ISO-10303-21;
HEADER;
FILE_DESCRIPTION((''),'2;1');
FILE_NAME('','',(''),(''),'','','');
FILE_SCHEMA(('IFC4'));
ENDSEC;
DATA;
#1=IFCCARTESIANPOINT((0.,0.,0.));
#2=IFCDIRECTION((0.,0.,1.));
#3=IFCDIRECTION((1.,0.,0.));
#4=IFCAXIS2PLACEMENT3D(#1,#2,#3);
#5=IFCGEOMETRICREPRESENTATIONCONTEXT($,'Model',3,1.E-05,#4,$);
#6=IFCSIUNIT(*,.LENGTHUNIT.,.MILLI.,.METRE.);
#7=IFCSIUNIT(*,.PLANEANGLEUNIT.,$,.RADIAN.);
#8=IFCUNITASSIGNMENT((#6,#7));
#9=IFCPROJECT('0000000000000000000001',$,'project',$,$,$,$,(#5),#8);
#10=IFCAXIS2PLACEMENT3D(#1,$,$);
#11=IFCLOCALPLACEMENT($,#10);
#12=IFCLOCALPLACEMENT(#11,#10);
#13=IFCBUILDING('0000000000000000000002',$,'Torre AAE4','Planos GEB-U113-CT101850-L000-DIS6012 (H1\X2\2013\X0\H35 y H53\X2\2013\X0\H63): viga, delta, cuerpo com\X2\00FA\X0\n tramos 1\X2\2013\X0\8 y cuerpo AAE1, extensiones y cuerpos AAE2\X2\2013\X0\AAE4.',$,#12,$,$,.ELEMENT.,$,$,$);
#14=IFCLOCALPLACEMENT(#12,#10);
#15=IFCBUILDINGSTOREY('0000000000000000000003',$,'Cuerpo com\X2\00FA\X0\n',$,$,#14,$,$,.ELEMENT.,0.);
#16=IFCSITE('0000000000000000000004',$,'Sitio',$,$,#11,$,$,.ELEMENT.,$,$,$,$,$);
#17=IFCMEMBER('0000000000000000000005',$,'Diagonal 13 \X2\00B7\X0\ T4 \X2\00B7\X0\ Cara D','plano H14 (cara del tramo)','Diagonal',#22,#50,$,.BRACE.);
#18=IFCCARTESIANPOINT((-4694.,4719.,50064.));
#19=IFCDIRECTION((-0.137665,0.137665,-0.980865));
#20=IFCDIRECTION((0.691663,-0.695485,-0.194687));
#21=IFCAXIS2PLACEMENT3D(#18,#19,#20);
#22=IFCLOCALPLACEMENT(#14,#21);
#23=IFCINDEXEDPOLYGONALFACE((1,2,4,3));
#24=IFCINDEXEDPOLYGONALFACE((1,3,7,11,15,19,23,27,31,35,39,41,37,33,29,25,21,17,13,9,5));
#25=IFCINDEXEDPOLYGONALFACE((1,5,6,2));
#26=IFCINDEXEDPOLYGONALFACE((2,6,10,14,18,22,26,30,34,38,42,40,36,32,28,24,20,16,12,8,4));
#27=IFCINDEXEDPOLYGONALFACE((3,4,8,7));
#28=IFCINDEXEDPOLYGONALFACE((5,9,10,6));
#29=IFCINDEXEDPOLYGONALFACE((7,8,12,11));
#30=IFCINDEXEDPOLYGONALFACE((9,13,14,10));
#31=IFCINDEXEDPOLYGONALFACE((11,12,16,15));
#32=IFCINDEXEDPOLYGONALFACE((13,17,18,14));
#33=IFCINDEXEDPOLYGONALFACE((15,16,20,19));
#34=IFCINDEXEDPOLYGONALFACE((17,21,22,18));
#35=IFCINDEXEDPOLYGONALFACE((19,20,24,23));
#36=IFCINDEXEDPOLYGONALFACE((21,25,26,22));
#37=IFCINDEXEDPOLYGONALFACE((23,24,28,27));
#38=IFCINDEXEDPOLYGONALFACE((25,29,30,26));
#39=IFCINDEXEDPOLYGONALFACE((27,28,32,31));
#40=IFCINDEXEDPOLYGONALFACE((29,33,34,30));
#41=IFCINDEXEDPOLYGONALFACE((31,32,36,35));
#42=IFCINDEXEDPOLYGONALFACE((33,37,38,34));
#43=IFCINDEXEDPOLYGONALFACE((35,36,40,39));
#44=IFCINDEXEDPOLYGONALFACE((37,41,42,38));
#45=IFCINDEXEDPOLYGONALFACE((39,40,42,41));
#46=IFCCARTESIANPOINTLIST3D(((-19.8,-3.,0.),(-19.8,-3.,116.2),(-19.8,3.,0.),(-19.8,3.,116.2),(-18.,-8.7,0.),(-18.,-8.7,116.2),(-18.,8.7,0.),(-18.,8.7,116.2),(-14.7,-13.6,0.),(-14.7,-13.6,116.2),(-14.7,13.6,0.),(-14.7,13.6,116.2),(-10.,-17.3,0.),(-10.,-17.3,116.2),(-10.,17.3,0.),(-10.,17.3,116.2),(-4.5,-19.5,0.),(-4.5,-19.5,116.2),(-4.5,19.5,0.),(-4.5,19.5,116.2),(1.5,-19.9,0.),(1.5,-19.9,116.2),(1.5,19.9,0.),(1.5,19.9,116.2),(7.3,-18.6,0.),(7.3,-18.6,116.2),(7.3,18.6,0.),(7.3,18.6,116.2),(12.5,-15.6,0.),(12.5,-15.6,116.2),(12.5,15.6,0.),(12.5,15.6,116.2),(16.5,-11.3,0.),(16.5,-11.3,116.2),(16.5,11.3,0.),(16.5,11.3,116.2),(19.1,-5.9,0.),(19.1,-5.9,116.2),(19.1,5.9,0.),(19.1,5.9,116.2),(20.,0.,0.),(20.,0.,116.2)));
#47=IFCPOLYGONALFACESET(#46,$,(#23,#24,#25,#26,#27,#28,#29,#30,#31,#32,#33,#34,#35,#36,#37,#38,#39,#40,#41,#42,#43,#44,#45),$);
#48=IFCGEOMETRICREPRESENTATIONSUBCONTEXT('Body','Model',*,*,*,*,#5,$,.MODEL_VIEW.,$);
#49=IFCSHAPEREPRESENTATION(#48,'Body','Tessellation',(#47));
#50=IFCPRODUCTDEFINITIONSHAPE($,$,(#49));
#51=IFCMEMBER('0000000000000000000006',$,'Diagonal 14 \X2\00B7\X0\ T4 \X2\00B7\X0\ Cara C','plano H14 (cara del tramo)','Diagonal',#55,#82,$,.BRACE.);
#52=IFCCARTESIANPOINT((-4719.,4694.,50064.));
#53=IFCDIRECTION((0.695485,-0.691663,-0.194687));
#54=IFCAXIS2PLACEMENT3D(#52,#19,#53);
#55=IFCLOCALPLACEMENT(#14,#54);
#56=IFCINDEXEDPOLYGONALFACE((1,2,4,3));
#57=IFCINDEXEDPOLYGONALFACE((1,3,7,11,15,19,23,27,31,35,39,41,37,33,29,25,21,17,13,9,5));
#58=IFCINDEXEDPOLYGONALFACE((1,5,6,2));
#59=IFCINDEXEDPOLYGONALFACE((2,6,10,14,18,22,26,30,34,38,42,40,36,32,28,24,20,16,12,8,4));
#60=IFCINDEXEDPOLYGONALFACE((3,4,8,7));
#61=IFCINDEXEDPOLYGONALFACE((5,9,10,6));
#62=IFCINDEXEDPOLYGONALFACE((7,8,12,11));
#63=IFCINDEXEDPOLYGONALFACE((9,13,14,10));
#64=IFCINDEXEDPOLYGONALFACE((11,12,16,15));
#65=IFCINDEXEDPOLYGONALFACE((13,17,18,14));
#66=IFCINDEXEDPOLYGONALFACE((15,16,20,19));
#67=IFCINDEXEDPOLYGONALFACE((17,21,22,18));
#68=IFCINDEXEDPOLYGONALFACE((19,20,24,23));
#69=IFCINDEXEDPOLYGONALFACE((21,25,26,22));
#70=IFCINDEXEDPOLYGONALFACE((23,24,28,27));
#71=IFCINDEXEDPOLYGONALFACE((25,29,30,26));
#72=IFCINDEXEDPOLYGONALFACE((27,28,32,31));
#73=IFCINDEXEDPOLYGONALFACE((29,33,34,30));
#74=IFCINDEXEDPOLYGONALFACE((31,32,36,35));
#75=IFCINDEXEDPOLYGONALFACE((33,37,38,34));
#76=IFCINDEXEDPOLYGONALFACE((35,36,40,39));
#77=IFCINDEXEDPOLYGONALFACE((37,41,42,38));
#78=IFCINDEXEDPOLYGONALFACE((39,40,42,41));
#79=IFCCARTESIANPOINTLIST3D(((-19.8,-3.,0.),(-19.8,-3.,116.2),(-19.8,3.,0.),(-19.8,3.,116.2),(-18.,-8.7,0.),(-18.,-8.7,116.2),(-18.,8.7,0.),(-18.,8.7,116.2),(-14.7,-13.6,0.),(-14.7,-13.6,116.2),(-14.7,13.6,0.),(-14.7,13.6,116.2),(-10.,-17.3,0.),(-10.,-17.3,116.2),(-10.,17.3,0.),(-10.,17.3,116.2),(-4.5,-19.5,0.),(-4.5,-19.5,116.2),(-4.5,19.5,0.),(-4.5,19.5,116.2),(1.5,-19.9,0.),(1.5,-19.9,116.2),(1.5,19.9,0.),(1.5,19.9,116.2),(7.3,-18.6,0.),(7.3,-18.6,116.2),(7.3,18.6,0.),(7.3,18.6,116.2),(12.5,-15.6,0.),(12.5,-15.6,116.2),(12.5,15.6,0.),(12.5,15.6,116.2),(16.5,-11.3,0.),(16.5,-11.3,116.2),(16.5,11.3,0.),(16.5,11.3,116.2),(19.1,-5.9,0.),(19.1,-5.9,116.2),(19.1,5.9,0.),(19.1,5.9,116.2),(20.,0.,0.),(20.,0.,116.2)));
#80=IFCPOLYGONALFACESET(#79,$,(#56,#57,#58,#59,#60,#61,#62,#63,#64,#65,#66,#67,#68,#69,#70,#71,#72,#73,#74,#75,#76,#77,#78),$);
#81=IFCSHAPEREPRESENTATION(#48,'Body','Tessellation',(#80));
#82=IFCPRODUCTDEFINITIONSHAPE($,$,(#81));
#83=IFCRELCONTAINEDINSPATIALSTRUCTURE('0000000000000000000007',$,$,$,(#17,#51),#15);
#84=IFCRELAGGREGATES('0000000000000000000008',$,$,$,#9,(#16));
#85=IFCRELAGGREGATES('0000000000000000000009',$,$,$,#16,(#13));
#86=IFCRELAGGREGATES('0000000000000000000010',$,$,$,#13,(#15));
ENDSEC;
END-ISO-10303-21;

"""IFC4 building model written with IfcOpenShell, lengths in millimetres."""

from ifc_helpers import new_model, si_unit, frame, origin, origin_with_axes, place, context, subcontext, project, spatial, circle, extrude, element, save


model = new_model("IFC4")

# Units and contexts
model_context = context("Model", 3, precision=1e-05, world=origin_with_axes())
body_context = subcontext(model_context, "Body", "Model", "MODEL_VIEW")
ifc_project = project(units=[si_unit("LENGTHUNIT", "METRE", prefix="MILLI"), si_unit("PLANEANGLEUNIT", "RADIAN")], contexts=[model_context])

# Site, building, storey
site_placement = place(None, origin())
site = spatial("IfcSite", under=ifc_project, at=site_placement, Name="Sitio", CompositionType="ELEMENT")
building_placement = place(site_placement, origin())
building = spatial("IfcBuilding", under=site, at=building_placement, Name="Torre AAE4", Description="Planos GEB-U113-CT101850-L000-DIS6012 (H1–H35 y H53–H63): viga, delta, cuerpo común tramos 1–8 y cuerpo AAE1, extensiones y cuerpos AAE2–AAE4.", CompositionType="ELEMENT")
storey_placement = place(building_placement, origin())
storey = spatial("IfcBuildingStorey", under=building, at=storey_placement, Name="Cuerpo común", CompositionType="ELEMENT", Elevation=0.0)

# Members
for number, where, z_axis, x_axis, name in (
    (1, (-4694.0, 4719.0, 50064.0), (-0.137665, 0.137665, -0.980865), (0.691663, -0.695485, -0.194687), "Diagonal 13 · T4 · Cara D"),
    (2, (-4719.0, 4694.0, 50064.0), (-0.137665, 0.137665, -0.980865), (0.695485, -0.691663, -0.194687), "Diagonal 14 · T4 · Cara C"),
):
    element("IfcMember", number, at=place(storey_placement, frame(where, z_axis=z_axis, x_axis=x_axis)), inside=storey, Name=name, Description="plano H14 (cara del tramo)", ObjectType="Diagonal", PredefinedType="BRACE", context=body_context, shape_type="SweptSolid", body=[
        extrude(circle(Radius=20.0), None, (0.0, 0.0, 1.0), 116.2),
    ])

save(model, "model.ifc")
